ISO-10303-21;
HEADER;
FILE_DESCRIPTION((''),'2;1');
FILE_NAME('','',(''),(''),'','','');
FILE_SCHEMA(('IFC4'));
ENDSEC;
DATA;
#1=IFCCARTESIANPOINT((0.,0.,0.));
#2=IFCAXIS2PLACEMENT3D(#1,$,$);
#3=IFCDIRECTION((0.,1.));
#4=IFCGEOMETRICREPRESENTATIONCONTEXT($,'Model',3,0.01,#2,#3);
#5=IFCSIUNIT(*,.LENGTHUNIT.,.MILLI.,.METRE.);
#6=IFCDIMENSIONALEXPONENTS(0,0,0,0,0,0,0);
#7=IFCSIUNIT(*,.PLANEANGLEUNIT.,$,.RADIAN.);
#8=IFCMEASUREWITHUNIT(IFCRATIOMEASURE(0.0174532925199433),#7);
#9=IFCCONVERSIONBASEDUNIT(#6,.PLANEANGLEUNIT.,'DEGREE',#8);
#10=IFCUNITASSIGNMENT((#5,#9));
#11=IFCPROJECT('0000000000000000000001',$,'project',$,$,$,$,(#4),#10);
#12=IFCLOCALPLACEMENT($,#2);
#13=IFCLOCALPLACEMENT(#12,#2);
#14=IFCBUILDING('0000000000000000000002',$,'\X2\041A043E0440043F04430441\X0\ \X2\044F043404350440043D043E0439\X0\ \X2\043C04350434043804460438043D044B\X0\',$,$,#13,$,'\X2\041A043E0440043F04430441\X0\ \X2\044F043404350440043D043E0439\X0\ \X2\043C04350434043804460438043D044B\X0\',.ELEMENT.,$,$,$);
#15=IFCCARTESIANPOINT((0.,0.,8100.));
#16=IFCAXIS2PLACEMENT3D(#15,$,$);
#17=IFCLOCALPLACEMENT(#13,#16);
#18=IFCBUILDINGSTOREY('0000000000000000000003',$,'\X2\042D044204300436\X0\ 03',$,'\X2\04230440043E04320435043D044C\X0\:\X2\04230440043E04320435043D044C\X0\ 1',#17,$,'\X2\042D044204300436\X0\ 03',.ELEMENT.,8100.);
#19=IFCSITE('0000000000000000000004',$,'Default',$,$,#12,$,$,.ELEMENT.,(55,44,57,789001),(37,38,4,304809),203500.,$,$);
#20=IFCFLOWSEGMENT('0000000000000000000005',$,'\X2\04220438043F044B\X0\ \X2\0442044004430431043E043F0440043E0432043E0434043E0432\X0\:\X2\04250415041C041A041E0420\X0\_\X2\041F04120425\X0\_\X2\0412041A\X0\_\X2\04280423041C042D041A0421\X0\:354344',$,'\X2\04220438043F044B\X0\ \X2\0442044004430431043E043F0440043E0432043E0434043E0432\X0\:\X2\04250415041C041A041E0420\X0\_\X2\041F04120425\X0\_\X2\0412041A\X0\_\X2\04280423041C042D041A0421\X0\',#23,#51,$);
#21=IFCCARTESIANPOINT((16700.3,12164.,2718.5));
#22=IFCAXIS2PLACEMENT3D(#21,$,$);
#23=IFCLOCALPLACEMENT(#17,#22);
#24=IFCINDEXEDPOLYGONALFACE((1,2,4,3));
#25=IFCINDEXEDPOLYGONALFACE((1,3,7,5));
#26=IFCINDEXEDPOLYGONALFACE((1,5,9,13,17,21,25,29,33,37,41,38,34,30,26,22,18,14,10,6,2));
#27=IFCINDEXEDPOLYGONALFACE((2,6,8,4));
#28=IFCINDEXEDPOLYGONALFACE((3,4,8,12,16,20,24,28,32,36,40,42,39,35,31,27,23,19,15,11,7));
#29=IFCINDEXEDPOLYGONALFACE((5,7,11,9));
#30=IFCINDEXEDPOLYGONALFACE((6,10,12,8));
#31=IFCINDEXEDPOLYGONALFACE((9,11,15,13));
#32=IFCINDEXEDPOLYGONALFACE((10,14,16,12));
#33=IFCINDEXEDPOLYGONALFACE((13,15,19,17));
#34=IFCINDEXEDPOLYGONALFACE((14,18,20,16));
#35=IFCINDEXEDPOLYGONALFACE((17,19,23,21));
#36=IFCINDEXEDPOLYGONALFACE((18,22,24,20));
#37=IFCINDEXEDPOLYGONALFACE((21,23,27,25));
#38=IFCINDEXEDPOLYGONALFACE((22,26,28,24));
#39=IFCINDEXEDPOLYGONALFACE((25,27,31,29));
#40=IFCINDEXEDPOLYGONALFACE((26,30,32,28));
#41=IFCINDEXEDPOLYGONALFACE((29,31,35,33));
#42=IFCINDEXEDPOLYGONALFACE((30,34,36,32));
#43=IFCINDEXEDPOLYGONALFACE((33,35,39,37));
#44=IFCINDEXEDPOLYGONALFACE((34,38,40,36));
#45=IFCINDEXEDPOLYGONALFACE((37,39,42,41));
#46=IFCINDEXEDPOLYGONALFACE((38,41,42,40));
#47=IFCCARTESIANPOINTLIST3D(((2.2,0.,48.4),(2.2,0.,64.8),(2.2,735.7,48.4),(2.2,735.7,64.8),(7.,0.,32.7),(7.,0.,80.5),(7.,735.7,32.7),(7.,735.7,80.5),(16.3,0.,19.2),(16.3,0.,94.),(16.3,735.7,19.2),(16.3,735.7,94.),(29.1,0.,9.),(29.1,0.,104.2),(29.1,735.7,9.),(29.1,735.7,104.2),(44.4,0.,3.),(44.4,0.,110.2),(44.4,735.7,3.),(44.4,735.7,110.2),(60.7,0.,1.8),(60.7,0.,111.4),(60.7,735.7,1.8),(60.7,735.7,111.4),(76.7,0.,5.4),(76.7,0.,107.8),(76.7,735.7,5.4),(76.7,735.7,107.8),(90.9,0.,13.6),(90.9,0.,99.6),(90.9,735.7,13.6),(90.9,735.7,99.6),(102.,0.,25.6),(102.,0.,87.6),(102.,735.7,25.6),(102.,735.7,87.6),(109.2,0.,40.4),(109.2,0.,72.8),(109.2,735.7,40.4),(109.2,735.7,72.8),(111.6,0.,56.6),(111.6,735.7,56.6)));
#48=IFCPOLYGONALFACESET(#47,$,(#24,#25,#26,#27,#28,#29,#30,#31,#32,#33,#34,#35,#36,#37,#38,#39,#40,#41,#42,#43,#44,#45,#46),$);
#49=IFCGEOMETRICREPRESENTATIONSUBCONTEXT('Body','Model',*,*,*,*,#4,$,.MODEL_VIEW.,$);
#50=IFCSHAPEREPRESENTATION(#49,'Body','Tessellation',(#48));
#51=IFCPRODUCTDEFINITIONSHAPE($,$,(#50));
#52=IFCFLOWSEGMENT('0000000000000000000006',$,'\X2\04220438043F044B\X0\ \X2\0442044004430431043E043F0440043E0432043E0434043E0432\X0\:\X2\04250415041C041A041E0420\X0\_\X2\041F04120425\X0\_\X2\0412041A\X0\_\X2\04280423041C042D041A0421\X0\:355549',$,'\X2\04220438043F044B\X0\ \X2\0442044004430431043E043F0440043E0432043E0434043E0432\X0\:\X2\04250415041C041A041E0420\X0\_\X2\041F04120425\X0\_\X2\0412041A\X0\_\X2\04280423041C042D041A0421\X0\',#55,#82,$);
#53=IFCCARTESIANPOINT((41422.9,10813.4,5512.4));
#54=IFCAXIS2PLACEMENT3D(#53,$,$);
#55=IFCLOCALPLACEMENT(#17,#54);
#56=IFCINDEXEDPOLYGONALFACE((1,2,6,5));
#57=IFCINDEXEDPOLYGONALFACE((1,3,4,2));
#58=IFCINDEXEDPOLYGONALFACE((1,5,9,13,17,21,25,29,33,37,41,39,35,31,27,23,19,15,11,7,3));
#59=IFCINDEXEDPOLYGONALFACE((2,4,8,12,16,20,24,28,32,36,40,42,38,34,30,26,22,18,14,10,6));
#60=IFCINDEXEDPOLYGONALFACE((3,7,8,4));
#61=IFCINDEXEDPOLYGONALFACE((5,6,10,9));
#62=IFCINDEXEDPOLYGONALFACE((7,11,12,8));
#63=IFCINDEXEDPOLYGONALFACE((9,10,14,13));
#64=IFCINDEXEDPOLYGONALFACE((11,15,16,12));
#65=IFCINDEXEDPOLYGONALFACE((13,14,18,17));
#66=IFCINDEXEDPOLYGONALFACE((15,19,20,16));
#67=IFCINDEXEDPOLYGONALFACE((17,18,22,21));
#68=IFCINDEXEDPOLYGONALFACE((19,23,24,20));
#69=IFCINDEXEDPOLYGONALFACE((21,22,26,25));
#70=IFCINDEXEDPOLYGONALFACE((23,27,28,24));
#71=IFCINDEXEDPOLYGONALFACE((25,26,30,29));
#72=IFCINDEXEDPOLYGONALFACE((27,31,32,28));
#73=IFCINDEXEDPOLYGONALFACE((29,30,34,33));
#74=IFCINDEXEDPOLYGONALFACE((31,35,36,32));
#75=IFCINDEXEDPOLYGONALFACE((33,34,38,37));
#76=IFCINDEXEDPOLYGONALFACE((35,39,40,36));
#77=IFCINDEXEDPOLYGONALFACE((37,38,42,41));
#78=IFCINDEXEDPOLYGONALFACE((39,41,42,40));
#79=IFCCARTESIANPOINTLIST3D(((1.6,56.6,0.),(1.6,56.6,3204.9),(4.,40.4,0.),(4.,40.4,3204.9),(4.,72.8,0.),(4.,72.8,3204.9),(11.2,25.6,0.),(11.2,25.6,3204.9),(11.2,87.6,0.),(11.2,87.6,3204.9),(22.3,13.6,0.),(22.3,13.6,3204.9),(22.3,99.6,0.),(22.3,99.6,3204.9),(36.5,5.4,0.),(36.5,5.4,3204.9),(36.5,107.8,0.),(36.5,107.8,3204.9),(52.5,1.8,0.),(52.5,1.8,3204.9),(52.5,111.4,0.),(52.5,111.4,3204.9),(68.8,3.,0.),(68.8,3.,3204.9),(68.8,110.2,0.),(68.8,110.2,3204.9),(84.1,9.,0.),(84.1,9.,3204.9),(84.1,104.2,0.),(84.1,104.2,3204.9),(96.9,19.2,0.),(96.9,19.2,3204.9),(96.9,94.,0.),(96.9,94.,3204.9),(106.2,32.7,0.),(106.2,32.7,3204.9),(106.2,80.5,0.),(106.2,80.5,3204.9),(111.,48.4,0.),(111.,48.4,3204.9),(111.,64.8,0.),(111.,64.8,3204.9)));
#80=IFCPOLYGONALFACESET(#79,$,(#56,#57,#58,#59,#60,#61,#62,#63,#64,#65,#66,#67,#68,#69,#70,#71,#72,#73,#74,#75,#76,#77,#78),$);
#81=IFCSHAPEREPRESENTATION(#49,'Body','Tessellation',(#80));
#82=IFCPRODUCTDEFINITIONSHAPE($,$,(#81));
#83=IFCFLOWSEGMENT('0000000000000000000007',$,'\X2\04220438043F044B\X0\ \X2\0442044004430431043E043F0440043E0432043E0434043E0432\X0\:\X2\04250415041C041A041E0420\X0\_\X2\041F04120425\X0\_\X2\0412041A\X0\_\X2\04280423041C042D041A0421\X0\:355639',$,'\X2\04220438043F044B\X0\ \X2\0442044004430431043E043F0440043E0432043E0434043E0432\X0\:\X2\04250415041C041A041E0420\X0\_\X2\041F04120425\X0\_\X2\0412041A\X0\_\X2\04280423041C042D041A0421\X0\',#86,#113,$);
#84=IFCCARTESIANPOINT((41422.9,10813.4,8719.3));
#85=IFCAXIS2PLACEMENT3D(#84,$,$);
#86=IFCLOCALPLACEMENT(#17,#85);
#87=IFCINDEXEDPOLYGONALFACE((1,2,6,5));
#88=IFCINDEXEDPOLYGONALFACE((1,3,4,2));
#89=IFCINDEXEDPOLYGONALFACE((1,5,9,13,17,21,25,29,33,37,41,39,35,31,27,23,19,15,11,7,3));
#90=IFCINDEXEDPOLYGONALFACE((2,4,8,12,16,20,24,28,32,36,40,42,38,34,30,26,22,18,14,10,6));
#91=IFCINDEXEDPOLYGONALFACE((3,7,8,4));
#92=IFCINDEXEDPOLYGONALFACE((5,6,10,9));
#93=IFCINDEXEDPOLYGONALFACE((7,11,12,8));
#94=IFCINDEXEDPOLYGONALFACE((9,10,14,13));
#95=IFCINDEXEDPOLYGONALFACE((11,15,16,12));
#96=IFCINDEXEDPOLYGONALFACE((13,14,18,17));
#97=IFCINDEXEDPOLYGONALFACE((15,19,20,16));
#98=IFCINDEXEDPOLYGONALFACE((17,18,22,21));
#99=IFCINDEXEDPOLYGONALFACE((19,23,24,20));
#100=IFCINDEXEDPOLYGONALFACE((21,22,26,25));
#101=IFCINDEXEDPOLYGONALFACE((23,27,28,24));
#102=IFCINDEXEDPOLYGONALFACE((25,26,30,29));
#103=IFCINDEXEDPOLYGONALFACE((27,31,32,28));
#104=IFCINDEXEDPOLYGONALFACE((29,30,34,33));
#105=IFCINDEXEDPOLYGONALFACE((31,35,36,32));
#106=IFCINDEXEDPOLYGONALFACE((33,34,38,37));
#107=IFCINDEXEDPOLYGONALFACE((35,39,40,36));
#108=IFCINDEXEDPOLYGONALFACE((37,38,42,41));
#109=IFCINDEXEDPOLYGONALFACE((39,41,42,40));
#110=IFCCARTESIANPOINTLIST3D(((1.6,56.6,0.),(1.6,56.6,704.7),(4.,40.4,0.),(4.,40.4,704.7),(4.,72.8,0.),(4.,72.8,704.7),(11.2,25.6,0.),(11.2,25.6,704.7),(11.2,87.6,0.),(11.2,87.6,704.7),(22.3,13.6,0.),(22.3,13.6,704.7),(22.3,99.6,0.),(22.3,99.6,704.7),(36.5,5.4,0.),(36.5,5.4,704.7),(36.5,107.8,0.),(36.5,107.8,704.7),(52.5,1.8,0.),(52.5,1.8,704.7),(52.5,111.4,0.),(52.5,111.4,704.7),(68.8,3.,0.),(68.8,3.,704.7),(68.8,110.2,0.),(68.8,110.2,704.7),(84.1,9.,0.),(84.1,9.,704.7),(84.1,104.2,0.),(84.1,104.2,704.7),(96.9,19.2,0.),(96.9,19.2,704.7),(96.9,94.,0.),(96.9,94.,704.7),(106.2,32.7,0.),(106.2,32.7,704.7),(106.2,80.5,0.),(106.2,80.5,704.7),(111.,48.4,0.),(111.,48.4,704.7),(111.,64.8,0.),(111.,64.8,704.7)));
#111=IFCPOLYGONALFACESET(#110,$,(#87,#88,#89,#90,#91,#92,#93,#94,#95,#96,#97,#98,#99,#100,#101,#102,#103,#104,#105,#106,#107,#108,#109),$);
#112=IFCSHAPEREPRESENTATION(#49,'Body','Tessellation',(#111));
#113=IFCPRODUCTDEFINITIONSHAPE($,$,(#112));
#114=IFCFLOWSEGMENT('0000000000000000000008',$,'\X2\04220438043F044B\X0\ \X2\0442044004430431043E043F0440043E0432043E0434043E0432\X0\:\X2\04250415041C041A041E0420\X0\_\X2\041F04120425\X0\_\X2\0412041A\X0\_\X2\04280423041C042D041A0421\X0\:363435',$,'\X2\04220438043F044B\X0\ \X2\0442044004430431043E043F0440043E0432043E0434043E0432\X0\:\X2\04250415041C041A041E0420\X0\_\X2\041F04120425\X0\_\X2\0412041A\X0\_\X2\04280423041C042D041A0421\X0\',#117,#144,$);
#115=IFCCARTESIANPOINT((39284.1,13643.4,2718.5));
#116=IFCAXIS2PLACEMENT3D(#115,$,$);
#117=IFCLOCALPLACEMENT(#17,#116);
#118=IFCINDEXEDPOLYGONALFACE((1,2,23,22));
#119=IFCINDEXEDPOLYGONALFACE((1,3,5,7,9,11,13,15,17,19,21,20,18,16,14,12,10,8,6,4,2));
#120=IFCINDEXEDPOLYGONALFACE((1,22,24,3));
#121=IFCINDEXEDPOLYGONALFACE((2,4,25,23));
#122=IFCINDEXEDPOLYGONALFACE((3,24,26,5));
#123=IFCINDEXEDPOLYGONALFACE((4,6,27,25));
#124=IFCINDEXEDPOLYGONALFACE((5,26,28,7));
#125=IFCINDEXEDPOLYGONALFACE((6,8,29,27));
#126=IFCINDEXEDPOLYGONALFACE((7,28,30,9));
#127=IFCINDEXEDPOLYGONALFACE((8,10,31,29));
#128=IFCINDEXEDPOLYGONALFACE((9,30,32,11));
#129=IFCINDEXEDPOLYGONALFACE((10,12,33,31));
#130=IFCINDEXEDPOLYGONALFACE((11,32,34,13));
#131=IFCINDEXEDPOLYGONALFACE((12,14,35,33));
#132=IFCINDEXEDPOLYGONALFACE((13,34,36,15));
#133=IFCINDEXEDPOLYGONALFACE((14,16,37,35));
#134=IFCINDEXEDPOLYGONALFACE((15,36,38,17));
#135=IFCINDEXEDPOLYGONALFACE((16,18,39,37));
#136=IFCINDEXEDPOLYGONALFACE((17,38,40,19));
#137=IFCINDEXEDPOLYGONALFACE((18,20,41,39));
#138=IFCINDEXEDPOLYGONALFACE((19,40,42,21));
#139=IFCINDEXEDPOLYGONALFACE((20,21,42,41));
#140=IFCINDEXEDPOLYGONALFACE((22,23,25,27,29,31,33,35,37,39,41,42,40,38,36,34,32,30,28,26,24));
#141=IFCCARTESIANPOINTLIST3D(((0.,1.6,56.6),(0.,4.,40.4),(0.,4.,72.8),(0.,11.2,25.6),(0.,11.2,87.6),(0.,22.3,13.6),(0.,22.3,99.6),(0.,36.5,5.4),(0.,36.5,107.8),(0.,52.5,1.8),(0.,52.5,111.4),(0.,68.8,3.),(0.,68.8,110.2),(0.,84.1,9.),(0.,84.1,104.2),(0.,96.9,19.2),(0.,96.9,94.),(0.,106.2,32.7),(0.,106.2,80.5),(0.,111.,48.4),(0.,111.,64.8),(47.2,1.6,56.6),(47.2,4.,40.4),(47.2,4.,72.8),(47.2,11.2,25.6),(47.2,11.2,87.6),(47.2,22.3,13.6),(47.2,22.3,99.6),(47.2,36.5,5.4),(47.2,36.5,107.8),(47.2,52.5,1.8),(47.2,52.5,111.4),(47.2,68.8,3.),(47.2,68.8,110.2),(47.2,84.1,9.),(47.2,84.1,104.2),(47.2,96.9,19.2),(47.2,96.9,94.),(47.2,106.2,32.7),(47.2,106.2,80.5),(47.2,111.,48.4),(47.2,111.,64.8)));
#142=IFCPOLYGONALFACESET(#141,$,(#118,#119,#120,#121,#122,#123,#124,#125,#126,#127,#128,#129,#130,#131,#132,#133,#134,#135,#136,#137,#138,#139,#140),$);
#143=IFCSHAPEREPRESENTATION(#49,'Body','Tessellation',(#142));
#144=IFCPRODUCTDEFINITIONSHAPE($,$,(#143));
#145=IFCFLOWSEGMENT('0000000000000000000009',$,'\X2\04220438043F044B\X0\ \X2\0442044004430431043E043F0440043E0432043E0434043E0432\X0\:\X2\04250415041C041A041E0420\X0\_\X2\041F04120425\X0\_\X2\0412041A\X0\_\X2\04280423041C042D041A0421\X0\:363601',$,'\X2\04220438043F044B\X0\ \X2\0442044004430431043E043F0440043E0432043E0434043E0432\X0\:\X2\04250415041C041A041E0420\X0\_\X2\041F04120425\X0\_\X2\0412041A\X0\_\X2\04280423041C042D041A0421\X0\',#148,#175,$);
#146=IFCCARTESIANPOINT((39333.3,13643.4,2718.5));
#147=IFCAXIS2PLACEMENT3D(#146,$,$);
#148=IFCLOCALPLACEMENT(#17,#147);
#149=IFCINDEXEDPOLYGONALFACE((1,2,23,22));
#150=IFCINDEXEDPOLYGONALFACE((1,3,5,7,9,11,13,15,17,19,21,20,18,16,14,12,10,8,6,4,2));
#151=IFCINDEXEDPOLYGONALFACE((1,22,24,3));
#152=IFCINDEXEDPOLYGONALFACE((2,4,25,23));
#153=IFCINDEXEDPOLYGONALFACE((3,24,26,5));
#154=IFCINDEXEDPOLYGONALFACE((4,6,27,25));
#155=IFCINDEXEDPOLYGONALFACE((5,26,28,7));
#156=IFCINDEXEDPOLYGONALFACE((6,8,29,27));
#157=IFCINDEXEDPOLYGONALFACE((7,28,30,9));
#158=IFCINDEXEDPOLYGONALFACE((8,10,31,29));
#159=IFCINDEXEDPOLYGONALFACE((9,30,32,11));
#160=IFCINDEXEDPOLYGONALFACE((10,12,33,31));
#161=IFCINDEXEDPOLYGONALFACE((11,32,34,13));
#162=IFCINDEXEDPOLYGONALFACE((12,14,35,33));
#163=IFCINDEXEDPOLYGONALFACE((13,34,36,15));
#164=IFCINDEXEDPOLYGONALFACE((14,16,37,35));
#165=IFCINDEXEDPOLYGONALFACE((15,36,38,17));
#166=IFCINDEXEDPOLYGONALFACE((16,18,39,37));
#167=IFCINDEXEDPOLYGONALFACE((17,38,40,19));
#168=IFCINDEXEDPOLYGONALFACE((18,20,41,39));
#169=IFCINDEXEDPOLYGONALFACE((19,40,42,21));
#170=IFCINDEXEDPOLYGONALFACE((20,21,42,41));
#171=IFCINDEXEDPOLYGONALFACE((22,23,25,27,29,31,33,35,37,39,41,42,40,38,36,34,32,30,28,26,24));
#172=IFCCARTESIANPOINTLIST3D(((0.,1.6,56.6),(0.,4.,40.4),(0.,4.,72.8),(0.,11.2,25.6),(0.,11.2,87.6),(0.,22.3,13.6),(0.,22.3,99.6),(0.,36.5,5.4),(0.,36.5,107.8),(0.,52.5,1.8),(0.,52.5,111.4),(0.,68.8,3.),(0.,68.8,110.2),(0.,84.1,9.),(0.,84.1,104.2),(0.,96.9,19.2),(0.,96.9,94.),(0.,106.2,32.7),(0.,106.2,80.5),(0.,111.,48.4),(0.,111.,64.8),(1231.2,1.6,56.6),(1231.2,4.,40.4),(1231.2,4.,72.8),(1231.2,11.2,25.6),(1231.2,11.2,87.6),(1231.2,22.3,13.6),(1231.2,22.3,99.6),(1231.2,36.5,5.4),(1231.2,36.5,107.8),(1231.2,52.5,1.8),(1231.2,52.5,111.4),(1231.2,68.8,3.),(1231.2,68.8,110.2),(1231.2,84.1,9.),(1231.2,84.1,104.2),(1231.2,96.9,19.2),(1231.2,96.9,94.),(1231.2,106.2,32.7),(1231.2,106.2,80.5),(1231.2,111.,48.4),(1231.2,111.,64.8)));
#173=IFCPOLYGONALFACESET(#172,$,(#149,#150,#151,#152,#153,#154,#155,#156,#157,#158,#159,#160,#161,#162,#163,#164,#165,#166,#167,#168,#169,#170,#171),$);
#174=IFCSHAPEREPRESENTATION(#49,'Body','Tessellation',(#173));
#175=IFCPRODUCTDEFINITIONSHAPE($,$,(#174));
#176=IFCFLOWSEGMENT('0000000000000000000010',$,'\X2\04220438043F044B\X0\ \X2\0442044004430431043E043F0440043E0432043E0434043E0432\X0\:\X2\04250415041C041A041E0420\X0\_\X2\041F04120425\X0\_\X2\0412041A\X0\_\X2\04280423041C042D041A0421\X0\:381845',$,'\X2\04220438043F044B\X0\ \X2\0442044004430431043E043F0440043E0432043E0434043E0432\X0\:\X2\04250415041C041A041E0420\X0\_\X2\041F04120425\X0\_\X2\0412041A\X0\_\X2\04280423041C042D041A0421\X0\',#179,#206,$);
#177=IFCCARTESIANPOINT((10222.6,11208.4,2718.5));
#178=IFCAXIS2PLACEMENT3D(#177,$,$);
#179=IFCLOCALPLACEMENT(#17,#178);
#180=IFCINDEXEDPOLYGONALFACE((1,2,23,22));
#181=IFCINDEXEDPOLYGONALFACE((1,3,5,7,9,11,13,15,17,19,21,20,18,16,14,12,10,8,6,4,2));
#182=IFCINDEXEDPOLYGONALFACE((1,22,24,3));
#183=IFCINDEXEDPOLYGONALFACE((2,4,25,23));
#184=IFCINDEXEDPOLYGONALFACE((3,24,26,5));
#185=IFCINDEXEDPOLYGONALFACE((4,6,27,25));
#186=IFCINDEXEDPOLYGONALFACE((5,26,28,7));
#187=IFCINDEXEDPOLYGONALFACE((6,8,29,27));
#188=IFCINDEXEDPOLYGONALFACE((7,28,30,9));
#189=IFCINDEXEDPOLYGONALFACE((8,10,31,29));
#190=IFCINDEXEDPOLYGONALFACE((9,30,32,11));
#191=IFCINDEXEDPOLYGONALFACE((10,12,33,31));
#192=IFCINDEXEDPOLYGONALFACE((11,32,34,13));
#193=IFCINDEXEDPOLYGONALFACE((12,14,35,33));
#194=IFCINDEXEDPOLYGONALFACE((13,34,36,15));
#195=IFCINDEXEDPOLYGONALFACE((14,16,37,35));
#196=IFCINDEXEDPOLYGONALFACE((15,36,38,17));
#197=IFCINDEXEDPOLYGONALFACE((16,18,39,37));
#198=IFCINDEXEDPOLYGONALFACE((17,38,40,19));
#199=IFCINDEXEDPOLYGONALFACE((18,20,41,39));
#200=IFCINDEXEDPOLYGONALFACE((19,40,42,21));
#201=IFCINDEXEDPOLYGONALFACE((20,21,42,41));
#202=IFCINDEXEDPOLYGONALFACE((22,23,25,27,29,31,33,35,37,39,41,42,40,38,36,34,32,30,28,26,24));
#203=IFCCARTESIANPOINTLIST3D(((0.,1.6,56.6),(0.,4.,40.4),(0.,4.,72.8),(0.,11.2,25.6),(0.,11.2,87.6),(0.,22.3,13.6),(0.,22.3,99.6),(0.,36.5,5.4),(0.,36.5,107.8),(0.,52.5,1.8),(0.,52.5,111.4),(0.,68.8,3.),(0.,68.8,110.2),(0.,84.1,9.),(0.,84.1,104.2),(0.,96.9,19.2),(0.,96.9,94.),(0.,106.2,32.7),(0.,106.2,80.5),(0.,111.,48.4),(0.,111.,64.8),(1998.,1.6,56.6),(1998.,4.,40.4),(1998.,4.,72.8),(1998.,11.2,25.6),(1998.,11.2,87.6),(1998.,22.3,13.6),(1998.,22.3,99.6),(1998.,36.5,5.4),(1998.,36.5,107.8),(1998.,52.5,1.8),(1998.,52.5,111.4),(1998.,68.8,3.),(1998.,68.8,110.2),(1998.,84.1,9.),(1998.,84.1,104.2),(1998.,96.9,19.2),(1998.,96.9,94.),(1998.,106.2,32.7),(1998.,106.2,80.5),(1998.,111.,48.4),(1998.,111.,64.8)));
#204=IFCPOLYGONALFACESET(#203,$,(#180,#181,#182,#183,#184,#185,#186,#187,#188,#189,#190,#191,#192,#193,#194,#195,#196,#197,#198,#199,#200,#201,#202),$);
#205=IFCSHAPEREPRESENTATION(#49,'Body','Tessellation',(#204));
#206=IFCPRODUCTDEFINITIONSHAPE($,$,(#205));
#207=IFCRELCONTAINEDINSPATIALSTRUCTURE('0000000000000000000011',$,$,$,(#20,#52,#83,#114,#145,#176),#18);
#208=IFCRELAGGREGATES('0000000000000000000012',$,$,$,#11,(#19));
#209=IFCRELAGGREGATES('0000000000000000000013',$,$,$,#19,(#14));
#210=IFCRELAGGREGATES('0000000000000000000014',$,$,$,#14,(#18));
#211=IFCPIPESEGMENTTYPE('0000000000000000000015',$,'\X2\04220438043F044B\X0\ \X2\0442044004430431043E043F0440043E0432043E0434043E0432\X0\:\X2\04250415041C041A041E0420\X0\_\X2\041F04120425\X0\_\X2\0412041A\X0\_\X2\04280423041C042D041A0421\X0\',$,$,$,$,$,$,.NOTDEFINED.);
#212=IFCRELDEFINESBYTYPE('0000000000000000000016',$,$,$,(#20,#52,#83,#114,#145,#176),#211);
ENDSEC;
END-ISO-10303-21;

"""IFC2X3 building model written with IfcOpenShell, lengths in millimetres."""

from ifc_helpers import new_model, entity, si_unit, converted_unit, direction, frame, origin, origin_2d_with_axis, place, context, subcontext, project, spatial, circle, extrude, type_object, element, save


model = new_model("IFC2X3")

# Units and contexts
model_context = context("Model", 3, precision=0.01, world=origin(), true_north=direction((0.0, 1.0)))
body_context = subcontext(model_context, "Body", "Model", "MODEL_VIEW")
ifc_project = project(units=[si_unit("LENGTHUNIT", "METRE", prefix="MILLI"), converted_unit("PLANEANGLEUNIT", "DEGREE", entity("IfcRatioMeasure", 0.0174532925199433), si_unit("PLANEANGLEUNIT", "RADIAN"), dimensions=[0, 0, 0, 0, 0, 0, 0])], contexts=[model_context])

# Site, building, storey
site_placement = place(None, origin())
site = spatial("IfcSite", under=ifc_project, at=site_placement, Name="Default", CompositionType="ELEMENT", RefLatitude=(55, 44, 57, 789001), RefLongitude=(37, 38, 4, 304809), RefElevation=203500.0)
building_placement = place(site_placement, origin())
building = spatial("IfcBuilding", under=site, at=building_placement, Name="Корпус ядерной медицины", LongName="Корпус ядерной медицины", CompositionType="ELEMENT")
storey_placement = place(building_placement, frame((0.0, 0.0, 8100.0)))
storey = spatial("IfcBuildingStorey", under=building, at=storey_placement, Name="Этаж 03", ObjectType="Уровень:Уровень 1", LongName="Этаж 03", CompositionType="ELEMENT", Elevation=8100.0)

# Flow segments
pipe_segment_type = type_object("IfcPipeSegmentType", Name="Типы трубопроводов:ХЕМКОР_ПВХ_ВК_ШУМЭКС", PredefinedType="NOTDEFINED")
flow_segment_1_placement = place(storey_placement, frame((16700.3, 12164.0, 2718.5)))
element("IfcFlowSegment", 1, at=flow_segment_1_placement, inside=storey, type_object=pipe_segment_type, Name="Типы трубопроводов:ХЕМКОР_ПВХ_ВК_ШУМЭКС:354344", ObjectType="Типы трубопроводов:ХЕМКОР_ПВХ_ВК_ШУМЭКС", context=body_context, shape_type="SweptSolid", body=[
    extrude(circle(Radius=55.0, at=origin_2d_with_axis()), frame((56.6, 0.0, 56.6), z_axis=(0.0, 1.0, 0.0), x_axis=(1.0, 0.0, 0.0)), (0.0, 0.0, 1.0), 735.7),
])
flow_segment_2_placement = place(storey_placement, frame((41422.9, 10813.4, 5512.4)))
element("IfcFlowSegment", 2, at=flow_segment_2_placement, inside=storey, type_object=pipe_segment_type, Name="Типы трубопроводов:ХЕМКОР_ПВХ_ВК_ШУМЭКС:355549", ObjectType="Типы трубопроводов:ХЕМКОР_ПВХ_ВК_ШУМЭКС", context=body_context, shape_type="SweptSolid", body=[
    extrude(circle(Radius=55.0, at=origin_2d_with_axis()), frame((56.6, 56.6, 0.0), z_axis=(0.0, 0.0, 1.0), x_axis=(-1.0, 0.0, 0.0)), (0.0, 0.0, 1.0), 3204.9),
])
flow_segment_3_placement = place(storey_placement, frame((41422.9, 10813.4, 8719.3)))
element("IfcFlowSegment", 3, at=flow_segment_3_placement, inside=storey, type_object=pipe_segment_type, Name="Типы трубопроводов:ХЕМКОР_ПВХ_ВК_ШУМЭКС:355639", ObjectType="Типы трубопроводов:ХЕМКОР_ПВХ_ВК_ШУМЭКС", context=body_context, shape_type="SweptSolid", body=[
    extrude(circle(Radius=55.0, at=origin_2d_with_axis()), frame((56.6, 56.6, 0.0), z_axis=(0.0, 0.0, 1.0), x_axis=(-1.0, 0.0, 0.0)), (0.0, 0.0, 1.0), 704.7),
])
flow_segment_4_placement = place(storey_placement, frame((39284.1, 13643.4, 2718.5)))
element("IfcFlowSegment", 4, at=flow_segment_4_placement, inside=storey, type_object=pipe_segment_type, Name="Типы трубопроводов:ХЕМКОР_ПВХ_ВК_ШУМЭКС:363435", ObjectType="Типы трубопроводов:ХЕМКОР_ПВХ_ВК_ШУМЭКС", context=body_context, shape_type="SweptSolid", body=[
    extrude(circle(Radius=55.0, at=origin_2d_with_axis()), frame((0.0, 56.6, 56.6), z_axis=(1.0, 0.0, 0.0), x_axis=(0.0, -1.0, 0.0)), (0.0, 0.0, 1.0), 47.2),
])
flow_segment_5_placement = place(storey_placement, frame((39333.3, 13643.4, 2718.5)))
element("IfcFlowSegment", 5, at=flow_segment_5_placement, inside=storey, type_object=pipe_segment_type, Name="Типы трубопроводов:ХЕМКОР_ПВХ_ВК_ШУМЭКС:363601", ObjectType="Типы трубопроводов:ХЕМКОР_ПВХ_ВК_ШУМЭКС", context=body_context, shape_type="SweptSolid", body=[
    extrude(circle(Radius=55.0, at=origin_2d_with_axis()), frame((0.0, 56.6, 56.6), z_axis=(1.0, 0.0, 0.0), x_axis=(0.0, -1.0, 0.0)), (0.0, 0.0, 1.0), 1231.2),
])
for number, where, name in (
    (6, (10222.6, 11208.4, 2718.5), "Типы трубопроводов:ХЕМКОР_ПВХ_ВК_ШУМЭКС:381845"),
):
    element("IfcFlowSegment", number, at=place(storey_placement, frame(where)), inside=storey, type_object=pipe_segment_type, Name=name, ObjectType="Типы трубопроводов:ХЕМКОР_ПВХ_ВК_ШУМЭКС", context=body_context, shape_type="SweptSolid", body=[
        extrude(circle(Radius=55.0, at=origin_2d_with_axis()), frame((0.0, 56.6, 56.6), z_axis=(1.0, 0.0, 0.0), x_axis=(0.0, -1.0, 0.0)), (0.0, 0.0, 1.0), 1998.0),
    ])

save(model, "model.ifc")
